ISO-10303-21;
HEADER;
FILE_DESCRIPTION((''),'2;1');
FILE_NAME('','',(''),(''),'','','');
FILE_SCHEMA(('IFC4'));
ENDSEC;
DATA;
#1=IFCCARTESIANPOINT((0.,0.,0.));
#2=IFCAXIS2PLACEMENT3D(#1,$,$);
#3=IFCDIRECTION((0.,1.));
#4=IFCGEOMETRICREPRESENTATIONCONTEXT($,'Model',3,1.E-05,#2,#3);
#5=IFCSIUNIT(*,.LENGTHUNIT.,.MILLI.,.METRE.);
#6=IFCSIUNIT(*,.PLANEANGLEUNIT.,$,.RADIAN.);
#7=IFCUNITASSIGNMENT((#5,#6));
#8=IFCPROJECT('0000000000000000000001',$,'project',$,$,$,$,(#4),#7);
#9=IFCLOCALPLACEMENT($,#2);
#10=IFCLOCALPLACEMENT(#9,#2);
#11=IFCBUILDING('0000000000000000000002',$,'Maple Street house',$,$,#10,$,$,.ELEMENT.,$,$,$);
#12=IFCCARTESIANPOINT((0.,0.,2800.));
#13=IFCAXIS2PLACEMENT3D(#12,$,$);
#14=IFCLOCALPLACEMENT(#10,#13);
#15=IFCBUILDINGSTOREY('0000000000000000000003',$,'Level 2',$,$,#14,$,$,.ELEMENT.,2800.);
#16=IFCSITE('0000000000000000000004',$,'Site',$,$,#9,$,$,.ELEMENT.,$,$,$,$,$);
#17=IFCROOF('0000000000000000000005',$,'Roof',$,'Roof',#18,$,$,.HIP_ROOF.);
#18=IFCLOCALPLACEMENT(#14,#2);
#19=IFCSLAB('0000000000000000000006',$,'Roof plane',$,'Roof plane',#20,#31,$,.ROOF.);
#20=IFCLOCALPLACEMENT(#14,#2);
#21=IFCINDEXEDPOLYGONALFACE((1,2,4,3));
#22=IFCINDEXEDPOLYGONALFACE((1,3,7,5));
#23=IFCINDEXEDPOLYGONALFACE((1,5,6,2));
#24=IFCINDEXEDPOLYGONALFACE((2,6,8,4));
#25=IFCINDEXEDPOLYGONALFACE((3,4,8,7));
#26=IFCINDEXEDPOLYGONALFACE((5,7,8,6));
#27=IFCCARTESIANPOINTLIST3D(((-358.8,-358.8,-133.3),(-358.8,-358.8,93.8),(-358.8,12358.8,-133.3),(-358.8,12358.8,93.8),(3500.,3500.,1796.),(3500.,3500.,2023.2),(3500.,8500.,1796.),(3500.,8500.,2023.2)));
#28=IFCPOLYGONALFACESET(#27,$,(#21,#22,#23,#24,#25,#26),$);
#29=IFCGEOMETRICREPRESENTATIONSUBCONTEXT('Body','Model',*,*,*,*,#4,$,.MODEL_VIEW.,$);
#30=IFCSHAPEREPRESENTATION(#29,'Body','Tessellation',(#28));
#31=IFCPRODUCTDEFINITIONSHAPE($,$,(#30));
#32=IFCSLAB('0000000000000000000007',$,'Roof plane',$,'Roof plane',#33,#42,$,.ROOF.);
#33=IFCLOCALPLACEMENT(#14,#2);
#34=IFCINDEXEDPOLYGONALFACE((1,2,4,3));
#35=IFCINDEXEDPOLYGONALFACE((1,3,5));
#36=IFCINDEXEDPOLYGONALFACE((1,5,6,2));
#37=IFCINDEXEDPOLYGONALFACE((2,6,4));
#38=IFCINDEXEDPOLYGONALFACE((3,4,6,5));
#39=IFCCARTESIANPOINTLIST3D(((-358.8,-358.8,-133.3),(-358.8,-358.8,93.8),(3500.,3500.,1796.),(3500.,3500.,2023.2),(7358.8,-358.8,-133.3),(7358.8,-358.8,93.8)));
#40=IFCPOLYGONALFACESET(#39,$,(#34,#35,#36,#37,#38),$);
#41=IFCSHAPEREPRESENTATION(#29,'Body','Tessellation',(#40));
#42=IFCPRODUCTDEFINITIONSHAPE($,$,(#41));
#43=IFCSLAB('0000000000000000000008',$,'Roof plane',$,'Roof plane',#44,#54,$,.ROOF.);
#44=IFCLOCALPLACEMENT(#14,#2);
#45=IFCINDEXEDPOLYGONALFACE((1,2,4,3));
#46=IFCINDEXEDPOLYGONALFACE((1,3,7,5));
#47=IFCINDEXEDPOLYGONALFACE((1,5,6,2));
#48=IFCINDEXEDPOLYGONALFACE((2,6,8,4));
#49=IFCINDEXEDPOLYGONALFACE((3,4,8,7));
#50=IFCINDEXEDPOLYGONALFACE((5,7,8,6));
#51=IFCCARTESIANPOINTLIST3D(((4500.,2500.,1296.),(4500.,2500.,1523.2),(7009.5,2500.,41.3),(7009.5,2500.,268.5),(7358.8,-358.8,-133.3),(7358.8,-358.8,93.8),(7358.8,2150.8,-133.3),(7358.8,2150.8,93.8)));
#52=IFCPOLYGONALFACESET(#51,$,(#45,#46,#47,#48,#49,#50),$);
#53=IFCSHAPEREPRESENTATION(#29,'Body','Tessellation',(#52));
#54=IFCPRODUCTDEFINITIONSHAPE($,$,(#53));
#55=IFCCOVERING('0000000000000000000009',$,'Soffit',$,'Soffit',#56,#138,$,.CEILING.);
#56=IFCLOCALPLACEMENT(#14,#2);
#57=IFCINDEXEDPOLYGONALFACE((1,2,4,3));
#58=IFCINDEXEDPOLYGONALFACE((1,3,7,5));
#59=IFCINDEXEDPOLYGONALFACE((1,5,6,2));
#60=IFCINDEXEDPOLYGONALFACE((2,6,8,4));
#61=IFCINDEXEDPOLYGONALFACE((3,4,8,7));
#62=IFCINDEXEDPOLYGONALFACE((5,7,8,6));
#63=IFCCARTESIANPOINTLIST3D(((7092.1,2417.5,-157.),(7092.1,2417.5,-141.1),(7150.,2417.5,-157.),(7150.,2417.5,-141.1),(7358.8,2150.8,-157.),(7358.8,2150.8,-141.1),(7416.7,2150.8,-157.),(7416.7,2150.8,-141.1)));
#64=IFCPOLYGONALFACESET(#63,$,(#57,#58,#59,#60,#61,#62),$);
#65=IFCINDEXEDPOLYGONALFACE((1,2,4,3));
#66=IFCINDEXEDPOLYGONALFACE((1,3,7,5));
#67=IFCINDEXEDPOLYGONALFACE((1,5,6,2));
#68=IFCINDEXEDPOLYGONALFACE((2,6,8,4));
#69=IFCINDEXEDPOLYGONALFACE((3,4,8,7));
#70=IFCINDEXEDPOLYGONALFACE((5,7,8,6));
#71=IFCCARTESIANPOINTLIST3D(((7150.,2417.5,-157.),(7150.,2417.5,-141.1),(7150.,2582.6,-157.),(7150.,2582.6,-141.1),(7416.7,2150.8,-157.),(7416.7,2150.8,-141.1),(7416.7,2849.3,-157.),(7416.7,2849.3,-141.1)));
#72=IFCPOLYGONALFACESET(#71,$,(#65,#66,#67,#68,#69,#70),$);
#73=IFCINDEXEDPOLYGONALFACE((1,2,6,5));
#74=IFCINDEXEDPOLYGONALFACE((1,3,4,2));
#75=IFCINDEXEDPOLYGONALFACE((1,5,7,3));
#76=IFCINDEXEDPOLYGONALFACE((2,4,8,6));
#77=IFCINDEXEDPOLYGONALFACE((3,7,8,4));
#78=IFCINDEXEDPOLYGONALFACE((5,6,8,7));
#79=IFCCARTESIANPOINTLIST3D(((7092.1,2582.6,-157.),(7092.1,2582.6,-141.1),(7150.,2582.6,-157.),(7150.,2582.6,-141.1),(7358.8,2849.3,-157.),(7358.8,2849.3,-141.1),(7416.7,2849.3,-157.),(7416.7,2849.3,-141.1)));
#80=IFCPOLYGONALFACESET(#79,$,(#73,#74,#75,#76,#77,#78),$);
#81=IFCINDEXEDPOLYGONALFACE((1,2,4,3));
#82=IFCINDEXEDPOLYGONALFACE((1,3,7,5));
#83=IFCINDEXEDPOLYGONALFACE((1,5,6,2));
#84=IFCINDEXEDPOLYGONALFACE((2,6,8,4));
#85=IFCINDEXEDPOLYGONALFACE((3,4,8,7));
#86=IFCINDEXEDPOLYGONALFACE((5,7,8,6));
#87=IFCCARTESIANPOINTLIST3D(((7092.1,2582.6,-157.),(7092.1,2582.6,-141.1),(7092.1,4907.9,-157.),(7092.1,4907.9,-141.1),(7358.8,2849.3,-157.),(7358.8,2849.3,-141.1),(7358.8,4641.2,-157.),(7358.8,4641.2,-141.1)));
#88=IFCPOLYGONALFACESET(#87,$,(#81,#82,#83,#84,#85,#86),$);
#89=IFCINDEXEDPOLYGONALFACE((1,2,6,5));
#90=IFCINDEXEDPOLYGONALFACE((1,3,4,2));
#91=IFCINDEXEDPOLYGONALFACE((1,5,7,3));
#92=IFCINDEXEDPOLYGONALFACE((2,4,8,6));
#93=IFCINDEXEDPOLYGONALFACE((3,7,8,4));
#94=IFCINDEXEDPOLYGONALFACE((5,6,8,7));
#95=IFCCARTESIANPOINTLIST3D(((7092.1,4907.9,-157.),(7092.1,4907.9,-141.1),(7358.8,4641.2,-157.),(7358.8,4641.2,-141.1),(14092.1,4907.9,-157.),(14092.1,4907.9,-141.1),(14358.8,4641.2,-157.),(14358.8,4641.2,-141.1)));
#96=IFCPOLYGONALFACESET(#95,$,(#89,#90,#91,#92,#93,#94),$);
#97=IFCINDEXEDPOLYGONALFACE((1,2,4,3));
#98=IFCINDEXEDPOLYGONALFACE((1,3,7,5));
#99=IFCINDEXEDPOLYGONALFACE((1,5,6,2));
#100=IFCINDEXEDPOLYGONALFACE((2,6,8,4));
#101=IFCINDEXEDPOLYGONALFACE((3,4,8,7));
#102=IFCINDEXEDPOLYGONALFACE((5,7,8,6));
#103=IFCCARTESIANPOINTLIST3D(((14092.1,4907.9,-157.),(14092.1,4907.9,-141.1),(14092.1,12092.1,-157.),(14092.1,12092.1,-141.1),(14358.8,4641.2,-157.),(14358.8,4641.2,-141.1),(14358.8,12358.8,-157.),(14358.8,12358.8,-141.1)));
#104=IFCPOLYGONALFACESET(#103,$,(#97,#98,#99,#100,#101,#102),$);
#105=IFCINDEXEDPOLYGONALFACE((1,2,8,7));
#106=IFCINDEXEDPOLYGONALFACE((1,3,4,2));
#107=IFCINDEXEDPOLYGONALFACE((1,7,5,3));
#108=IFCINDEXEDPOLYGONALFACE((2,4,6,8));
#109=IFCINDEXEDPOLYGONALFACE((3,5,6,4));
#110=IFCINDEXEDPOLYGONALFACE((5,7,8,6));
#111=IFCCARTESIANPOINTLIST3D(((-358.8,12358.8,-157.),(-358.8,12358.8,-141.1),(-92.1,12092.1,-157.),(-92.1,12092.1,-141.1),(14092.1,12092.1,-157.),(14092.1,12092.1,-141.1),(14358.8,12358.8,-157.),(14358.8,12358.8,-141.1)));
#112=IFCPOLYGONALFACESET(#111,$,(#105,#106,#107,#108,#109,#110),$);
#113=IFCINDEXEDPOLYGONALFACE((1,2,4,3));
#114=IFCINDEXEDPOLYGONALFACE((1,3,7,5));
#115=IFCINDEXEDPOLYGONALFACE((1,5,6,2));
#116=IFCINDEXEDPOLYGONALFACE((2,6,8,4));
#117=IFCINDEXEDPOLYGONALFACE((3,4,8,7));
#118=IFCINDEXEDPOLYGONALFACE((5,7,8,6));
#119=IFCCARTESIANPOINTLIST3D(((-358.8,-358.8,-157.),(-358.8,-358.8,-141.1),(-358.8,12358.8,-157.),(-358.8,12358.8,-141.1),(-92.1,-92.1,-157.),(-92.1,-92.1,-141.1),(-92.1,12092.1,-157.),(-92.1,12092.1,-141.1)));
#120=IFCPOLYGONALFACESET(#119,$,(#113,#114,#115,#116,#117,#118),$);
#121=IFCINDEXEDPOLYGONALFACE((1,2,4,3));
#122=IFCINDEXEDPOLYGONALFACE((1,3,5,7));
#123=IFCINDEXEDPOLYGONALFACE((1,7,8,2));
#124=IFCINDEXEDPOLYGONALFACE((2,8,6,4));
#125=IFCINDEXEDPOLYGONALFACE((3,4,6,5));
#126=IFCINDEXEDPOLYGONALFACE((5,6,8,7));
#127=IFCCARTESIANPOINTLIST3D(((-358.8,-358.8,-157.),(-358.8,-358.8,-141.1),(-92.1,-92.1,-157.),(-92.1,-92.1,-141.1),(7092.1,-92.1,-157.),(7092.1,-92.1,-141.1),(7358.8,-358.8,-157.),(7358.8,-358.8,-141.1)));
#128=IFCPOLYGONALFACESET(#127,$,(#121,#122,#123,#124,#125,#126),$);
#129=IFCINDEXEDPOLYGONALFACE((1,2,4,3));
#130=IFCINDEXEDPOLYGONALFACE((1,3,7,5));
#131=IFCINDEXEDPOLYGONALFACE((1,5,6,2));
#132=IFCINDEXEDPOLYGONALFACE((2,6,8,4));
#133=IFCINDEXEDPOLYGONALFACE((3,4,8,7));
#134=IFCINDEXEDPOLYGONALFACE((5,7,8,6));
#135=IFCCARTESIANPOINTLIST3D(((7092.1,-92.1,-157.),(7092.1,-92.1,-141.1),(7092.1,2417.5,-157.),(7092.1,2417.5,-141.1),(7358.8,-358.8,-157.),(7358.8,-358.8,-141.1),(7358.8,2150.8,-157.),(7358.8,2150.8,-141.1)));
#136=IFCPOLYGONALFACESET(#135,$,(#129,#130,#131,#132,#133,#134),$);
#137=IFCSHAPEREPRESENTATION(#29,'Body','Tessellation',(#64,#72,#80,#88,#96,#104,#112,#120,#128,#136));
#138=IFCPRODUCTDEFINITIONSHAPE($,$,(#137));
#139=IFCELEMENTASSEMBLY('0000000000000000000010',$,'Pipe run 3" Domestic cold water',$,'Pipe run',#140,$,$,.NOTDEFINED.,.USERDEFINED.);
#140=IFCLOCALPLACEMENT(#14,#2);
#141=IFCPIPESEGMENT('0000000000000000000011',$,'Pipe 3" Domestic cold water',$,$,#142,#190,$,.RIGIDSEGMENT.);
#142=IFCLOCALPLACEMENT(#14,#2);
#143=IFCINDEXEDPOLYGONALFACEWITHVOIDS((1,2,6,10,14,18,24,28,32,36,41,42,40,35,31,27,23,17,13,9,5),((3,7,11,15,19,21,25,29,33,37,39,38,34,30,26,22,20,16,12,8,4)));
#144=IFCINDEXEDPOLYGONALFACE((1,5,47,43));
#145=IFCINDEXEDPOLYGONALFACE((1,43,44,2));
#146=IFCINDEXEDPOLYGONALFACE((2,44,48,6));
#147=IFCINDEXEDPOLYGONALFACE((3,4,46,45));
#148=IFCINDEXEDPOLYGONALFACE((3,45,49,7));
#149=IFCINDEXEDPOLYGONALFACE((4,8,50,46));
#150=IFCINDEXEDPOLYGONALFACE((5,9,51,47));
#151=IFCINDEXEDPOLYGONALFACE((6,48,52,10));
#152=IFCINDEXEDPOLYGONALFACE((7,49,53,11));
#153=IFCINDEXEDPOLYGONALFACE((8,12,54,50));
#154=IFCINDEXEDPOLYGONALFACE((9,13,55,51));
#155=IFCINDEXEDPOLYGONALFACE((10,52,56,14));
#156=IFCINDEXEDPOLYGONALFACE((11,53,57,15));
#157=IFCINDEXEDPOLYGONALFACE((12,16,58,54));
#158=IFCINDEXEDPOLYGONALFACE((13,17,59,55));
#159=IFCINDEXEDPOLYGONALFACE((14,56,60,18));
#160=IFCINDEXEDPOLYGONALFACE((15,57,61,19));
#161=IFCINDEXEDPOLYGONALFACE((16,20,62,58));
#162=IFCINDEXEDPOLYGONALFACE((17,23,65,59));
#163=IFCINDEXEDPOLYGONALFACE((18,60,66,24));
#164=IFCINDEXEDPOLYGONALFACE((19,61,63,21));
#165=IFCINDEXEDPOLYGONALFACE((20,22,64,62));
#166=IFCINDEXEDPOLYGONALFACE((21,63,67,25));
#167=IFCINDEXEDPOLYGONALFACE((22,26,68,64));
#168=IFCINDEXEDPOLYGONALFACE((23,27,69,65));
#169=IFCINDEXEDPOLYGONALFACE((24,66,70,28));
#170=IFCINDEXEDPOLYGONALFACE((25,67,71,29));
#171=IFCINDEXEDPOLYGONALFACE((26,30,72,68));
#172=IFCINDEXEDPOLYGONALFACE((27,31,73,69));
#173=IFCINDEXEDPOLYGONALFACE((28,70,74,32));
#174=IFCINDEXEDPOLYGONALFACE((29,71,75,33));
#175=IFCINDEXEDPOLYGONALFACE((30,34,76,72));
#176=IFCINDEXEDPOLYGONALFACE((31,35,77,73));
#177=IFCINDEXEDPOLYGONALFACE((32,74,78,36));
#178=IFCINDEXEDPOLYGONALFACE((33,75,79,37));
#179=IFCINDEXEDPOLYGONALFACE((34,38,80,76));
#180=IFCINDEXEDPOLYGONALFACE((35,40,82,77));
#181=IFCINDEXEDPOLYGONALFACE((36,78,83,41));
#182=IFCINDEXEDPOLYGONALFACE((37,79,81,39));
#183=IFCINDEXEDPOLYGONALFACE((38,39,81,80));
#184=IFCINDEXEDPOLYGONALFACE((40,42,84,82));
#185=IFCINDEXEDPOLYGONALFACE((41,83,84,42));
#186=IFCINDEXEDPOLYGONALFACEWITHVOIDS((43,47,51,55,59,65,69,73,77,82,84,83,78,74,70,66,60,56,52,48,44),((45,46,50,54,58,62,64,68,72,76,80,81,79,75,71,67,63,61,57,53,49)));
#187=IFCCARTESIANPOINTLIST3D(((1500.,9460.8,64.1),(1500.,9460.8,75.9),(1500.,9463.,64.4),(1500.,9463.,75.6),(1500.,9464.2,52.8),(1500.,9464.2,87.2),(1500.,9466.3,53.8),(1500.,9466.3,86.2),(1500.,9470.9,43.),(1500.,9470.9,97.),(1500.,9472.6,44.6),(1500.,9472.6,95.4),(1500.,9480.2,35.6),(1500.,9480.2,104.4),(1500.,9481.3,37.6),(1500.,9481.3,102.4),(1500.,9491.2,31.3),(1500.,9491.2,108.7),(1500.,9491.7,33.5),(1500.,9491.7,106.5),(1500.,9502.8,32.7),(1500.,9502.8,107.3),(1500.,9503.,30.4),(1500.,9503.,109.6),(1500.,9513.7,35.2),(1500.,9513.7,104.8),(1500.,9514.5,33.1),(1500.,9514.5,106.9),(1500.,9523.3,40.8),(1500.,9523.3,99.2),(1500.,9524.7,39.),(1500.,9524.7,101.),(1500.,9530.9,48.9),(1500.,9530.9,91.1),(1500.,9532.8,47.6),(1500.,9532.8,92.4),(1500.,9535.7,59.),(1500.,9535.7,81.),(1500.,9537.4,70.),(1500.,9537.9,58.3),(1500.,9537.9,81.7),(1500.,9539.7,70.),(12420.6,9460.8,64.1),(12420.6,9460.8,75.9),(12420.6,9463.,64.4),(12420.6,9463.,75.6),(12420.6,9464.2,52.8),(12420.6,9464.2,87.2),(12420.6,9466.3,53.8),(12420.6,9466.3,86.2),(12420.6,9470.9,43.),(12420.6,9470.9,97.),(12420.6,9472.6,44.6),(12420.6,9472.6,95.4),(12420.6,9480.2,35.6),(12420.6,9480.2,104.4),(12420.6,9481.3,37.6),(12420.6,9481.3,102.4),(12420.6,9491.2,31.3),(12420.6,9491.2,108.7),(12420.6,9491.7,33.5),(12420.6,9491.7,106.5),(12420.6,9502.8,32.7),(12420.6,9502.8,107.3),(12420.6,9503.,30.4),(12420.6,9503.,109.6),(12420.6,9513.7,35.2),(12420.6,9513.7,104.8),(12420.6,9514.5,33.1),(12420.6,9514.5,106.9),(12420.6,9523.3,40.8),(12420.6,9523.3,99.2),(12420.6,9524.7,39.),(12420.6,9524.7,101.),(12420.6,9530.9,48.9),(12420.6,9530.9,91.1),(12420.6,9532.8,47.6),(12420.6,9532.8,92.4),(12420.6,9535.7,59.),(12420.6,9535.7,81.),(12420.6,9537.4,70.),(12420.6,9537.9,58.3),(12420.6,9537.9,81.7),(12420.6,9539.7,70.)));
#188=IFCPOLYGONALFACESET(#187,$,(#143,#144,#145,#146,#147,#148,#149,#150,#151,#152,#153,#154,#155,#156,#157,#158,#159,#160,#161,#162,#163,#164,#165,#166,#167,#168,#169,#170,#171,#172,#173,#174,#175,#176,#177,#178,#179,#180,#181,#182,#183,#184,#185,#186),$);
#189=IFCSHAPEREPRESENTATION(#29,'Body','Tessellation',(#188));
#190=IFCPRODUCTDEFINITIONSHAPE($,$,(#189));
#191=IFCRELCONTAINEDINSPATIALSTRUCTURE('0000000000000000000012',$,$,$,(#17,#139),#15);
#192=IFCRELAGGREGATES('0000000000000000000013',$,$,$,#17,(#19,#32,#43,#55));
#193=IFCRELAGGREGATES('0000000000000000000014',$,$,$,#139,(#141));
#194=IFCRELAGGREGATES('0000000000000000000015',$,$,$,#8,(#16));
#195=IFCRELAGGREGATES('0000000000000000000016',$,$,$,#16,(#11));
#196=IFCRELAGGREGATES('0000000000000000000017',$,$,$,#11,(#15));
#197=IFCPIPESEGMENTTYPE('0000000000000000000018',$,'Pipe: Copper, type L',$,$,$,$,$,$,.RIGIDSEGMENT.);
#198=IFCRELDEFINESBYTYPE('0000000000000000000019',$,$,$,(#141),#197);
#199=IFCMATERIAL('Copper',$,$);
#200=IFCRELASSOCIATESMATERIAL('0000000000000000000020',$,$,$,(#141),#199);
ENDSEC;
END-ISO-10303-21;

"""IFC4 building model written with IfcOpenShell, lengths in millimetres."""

from ifc_helpers import new_model, si_unit, direction, frame, origin, origin_with_axes, origin_2d, place, context, subcontext, project, spatial, polyline, hollow_circle, outline, extrude, material, type_object, element, aggregate, save


model = new_model("IFC4")

# Units and contexts
model_context = context("Model", 3, precision=1e-05, world=origin(), true_north=direction((0.0, 1.0)))
body_context = subcontext(model_context, "Body", "Model", "MODEL_VIEW")
ifc_project = project(units=[si_unit("LENGTHUNIT", "METRE", prefix="MILLI"), si_unit("PLANEANGLEUNIT", "RADIAN")], contexts=[model_context])

# Site, building, storey
site_placement = place(None, origin())
site = spatial("IfcSite", under=ifc_project, at=site_placement, Name="Site", CompositionType="ELEMENT")
building_placement = place(site_placement, origin())
building = spatial("IfcBuilding", under=site, at=building_placement, Name="Maple Street house", CompositionType="ELEMENT")
storey_placement = place(building_placement, frame((0.0, 0.0, 2800.0)))
storey = spatial("IfcBuildingStorey", under=building, at=storey_placement, Name="Level 2", CompositionType="ELEMENT", Elevation=2800.0)

# Roof
roof_1_placement = place(storey_placement, origin_with_axes())
roof_1 = element("IfcRoof", 1, at=roof_1_placement, inside=storey, Name="Roof", ObjectType="Roof", PredefinedType="HIP_ROOF")

# Slabs
slab_1_placement = place(storey_placement, origin_with_axes())
slab_1 = element("IfcSlab", 2, at=slab_1_placement, Name="Roof plane", ObjectType="Roof plane", PredefinedType="ROOF", context=body_context, shape_type="SweptSolid", body=[
    extrude(outline(polyline([(-12358.8, 0.0), (358.8, 0.0), (-3500.0, 4314.2), (-8500.0, 4314.2), (-12358.8, 0.0)])), frame((-358.8, 0.0, -133.3), z_axis=(-0.447214, 0.0, 0.894427), x_axis=(0.0, -1.0, 0.0)), (0.0, 0.447214, 0.894427), 227.2),
])
slab_2_placement = place(storey_placement, origin_with_axes())
slab_2 = element("IfcSlab", 3, at=slab_2_placement, Name="Roof plane", ObjectType="Roof plane", PredefinedType="ROOF", context=body_context, shape_type="SweptSolid", body=[
    extrude(outline(polyline([(-358.8, 0.0), (7358.8, 0.0), (3500.0, 4314.2), (-358.8, 0.0)])), frame((0.0, -358.8, -133.3), z_axis=(0.0, -0.447214, 0.894427), x_axis=(1.0, 0.0, 0.0)), (0.0, 0.447214, 0.894427), 227.2),
])
slab_3_placement = place(storey_placement, origin_with_axes())
slab_3 = element("IfcSlab", 4, at=slab_3_placement, Name="Roof plane", ObjectType="Roof plane", PredefinedType="ROOF", context=body_context, shape_type="SweptSolid", body=[
    extrude(outline(polyline([(-358.8, 0.0), (2150.8, 0.0), (2500.0, 390.5), (2500.0, 3196.2), (-358.8, 0.0)])), frame((7358.8, 0.0, -133.3), z_axis=(0.447214, 0.0, 0.894427), x_axis=(0.0, 1.0, 0.0)), (0.0, 0.447214, 0.894427), 227.2),
])

# Covering
covering_placement = place(storey_placement, origin_with_axes())
covering = element("IfcCovering", 5, at=covering_placement, Name="Soffit", ObjectType="Soffit", PredefinedType="CEILING", context=body_context, shape_type="SweptSolid", body=[
    extrude(outline(polyline([(7092.1, 2417.5), (7150.0, 2417.5), (7416.7, 2150.8), (7358.8, 2150.8), (7092.1, 2417.5)])), frame((0.0, 0.0, -157.0), z_axis=(0.0, 0.0, 1.0), x_axis=(1.0, 0.0, 0.0)), (0.0, 0.0, 1.0), 15.9),
    extrude(outline(polyline([(7150.0, 2417.5), (7150.0, 2582.6), (7416.7, 2849.3), (7416.7, 2150.8), (7150.0, 2417.5)])), frame((0.0, 0.0, -157.0), z_axis=(0.0, 0.0, 1.0), x_axis=(1.0, 0.0, 0.0)), (0.0, 0.0, 1.0), 15.9),
    extrude(outline(polyline([(7150.0, 2582.6), (7092.1, 2582.6), (7358.8, 2849.3), (7416.7, 2849.3), (7150.0, 2582.6)])), frame((0.0, 0.0, -157.0), z_axis=(0.0, 0.0, 1.0), x_axis=(1.0, 0.0, 0.0)), (0.0, 0.0, 1.0), 15.9),
    extrude(outline(polyline([(7092.1, 2582.6), (7092.1, 4907.9), (7358.8, 4641.2), (7358.8, 2849.3), (7092.1, 2582.6)])), frame((0.0, 0.0, -157.0), z_axis=(0.0, 0.0, 1.0), x_axis=(1.0, 0.0, 0.0)), (0.0, 0.0, 1.0), 15.9),
    extrude(outline(polyline([(7092.1, 4907.9), (14092.1, 4907.9), (14358.8, 4641.2), (7358.8, 4641.2), (7092.1, 4907.9)])), frame((0.0, 0.0, -157.0), z_axis=(0.0, 0.0, 1.0), x_axis=(1.0, 0.0, 0.0)), (0.0, 0.0, 1.0), 15.9),
    extrude(outline(polyline([(14092.1, 4907.9), (14092.1, 12092.1), (14358.8, 12358.8), (14358.8, 4641.2), (14092.1, 4907.9)])), frame((0.0, 0.0, -157.0), z_axis=(0.0, 0.0, 1.0), x_axis=(1.0, 0.0, 0.0)), (0.0, 0.0, 1.0), 15.9),
    extrude(outline(polyline([(14092.1, 12092.1), (-92.1, 12092.1), (-358.8, 12358.8), (14358.8, 12358.8), (14092.1, 12092.1)])), frame((0.0, 0.0, -157.0), z_axis=(0.0, 0.0, 1.0), x_axis=(1.0, 0.0, 0.0)), (0.0, 0.0, 1.0), 15.9),
    extrude(outline(polyline([(-92.1, 12092.1), (-92.1, -92.1), (-358.8, -358.8), (-358.8, 12358.8), (-92.1, 12092.1)])), frame((0.0, 0.0, -157.0), z_axis=(0.0, 0.0, 1.0), x_axis=(1.0, 0.0, 0.0)), (0.0, 0.0, 1.0), 15.9),
    extrude(outline(polyline([(-92.1, -92.1), (7092.1, -92.1), (7358.8, -358.8), (-358.8, -358.8), (-92.1, -92.1)])), frame((0.0, 0.0, -157.0), z_axis=(0.0, 0.0, 1.0), x_axis=(1.0, 0.0, 0.0)), (0.0, 0.0, 1.0), 15.9),
    extrude(outline(polyline([(7092.1, -92.1), (7092.1, 2417.5), (7358.8, 2150.8), (7358.8, -358.8), (7092.1, -92.1)])), frame((0.0, 0.0, -157.0), z_axis=(0.0, 0.0, 1.0), x_axis=(1.0, 0.0, 0.0)), (0.0, 0.0, 1.0), 15.9),
])
aggregate(roof_1, [slab_1, slab_2, slab_3, covering])

# Element assembly, pipe segment
assembly_placement = place(storey_placement, origin_with_axes())
assembly = element("IfcElementAssembly", 6, at=assembly_placement, inside=storey, Name="Pipe run 3\" Domestic cold water", ObjectType="Pipe run", AssemblyPlace="NOTDEFINED", PredefinedType="USERDEFINED")
ifc_material = material(Name="Copper")
pipe_segment_type = type_object("IfcPipeSegmentType", Name="Pipe: Copper, type L", PredefinedType="RIGIDSEGMENT")
pipe_segment_1_placement = place(storey_placement, origin_with_axes())
pipe_segment_1 = element("IfcPipeSegment", 7, at=pipe_segment_1_placement, type_object=pipe_segment_type, material=ifc_material, Name="Pipe 3\" Domestic cold water", PredefinedType="RIGIDSEGMENT", context=body_context, shape_type="SweptSolid", body=[
    extrude(hollow_circle(Radius=39.7, WallThickness=2.3, at=origin_2d()), frame((1500.0, 9500.0, 70.0), z_axis=(1.0, 0.0, 0.0), x_axis=(0.0, 1.0, 0.0)), (0.0, 0.0, 1.0), 10920.6),
])
aggregate(assembly, [pipe_segment_1])

save(model, "model.ifc")
